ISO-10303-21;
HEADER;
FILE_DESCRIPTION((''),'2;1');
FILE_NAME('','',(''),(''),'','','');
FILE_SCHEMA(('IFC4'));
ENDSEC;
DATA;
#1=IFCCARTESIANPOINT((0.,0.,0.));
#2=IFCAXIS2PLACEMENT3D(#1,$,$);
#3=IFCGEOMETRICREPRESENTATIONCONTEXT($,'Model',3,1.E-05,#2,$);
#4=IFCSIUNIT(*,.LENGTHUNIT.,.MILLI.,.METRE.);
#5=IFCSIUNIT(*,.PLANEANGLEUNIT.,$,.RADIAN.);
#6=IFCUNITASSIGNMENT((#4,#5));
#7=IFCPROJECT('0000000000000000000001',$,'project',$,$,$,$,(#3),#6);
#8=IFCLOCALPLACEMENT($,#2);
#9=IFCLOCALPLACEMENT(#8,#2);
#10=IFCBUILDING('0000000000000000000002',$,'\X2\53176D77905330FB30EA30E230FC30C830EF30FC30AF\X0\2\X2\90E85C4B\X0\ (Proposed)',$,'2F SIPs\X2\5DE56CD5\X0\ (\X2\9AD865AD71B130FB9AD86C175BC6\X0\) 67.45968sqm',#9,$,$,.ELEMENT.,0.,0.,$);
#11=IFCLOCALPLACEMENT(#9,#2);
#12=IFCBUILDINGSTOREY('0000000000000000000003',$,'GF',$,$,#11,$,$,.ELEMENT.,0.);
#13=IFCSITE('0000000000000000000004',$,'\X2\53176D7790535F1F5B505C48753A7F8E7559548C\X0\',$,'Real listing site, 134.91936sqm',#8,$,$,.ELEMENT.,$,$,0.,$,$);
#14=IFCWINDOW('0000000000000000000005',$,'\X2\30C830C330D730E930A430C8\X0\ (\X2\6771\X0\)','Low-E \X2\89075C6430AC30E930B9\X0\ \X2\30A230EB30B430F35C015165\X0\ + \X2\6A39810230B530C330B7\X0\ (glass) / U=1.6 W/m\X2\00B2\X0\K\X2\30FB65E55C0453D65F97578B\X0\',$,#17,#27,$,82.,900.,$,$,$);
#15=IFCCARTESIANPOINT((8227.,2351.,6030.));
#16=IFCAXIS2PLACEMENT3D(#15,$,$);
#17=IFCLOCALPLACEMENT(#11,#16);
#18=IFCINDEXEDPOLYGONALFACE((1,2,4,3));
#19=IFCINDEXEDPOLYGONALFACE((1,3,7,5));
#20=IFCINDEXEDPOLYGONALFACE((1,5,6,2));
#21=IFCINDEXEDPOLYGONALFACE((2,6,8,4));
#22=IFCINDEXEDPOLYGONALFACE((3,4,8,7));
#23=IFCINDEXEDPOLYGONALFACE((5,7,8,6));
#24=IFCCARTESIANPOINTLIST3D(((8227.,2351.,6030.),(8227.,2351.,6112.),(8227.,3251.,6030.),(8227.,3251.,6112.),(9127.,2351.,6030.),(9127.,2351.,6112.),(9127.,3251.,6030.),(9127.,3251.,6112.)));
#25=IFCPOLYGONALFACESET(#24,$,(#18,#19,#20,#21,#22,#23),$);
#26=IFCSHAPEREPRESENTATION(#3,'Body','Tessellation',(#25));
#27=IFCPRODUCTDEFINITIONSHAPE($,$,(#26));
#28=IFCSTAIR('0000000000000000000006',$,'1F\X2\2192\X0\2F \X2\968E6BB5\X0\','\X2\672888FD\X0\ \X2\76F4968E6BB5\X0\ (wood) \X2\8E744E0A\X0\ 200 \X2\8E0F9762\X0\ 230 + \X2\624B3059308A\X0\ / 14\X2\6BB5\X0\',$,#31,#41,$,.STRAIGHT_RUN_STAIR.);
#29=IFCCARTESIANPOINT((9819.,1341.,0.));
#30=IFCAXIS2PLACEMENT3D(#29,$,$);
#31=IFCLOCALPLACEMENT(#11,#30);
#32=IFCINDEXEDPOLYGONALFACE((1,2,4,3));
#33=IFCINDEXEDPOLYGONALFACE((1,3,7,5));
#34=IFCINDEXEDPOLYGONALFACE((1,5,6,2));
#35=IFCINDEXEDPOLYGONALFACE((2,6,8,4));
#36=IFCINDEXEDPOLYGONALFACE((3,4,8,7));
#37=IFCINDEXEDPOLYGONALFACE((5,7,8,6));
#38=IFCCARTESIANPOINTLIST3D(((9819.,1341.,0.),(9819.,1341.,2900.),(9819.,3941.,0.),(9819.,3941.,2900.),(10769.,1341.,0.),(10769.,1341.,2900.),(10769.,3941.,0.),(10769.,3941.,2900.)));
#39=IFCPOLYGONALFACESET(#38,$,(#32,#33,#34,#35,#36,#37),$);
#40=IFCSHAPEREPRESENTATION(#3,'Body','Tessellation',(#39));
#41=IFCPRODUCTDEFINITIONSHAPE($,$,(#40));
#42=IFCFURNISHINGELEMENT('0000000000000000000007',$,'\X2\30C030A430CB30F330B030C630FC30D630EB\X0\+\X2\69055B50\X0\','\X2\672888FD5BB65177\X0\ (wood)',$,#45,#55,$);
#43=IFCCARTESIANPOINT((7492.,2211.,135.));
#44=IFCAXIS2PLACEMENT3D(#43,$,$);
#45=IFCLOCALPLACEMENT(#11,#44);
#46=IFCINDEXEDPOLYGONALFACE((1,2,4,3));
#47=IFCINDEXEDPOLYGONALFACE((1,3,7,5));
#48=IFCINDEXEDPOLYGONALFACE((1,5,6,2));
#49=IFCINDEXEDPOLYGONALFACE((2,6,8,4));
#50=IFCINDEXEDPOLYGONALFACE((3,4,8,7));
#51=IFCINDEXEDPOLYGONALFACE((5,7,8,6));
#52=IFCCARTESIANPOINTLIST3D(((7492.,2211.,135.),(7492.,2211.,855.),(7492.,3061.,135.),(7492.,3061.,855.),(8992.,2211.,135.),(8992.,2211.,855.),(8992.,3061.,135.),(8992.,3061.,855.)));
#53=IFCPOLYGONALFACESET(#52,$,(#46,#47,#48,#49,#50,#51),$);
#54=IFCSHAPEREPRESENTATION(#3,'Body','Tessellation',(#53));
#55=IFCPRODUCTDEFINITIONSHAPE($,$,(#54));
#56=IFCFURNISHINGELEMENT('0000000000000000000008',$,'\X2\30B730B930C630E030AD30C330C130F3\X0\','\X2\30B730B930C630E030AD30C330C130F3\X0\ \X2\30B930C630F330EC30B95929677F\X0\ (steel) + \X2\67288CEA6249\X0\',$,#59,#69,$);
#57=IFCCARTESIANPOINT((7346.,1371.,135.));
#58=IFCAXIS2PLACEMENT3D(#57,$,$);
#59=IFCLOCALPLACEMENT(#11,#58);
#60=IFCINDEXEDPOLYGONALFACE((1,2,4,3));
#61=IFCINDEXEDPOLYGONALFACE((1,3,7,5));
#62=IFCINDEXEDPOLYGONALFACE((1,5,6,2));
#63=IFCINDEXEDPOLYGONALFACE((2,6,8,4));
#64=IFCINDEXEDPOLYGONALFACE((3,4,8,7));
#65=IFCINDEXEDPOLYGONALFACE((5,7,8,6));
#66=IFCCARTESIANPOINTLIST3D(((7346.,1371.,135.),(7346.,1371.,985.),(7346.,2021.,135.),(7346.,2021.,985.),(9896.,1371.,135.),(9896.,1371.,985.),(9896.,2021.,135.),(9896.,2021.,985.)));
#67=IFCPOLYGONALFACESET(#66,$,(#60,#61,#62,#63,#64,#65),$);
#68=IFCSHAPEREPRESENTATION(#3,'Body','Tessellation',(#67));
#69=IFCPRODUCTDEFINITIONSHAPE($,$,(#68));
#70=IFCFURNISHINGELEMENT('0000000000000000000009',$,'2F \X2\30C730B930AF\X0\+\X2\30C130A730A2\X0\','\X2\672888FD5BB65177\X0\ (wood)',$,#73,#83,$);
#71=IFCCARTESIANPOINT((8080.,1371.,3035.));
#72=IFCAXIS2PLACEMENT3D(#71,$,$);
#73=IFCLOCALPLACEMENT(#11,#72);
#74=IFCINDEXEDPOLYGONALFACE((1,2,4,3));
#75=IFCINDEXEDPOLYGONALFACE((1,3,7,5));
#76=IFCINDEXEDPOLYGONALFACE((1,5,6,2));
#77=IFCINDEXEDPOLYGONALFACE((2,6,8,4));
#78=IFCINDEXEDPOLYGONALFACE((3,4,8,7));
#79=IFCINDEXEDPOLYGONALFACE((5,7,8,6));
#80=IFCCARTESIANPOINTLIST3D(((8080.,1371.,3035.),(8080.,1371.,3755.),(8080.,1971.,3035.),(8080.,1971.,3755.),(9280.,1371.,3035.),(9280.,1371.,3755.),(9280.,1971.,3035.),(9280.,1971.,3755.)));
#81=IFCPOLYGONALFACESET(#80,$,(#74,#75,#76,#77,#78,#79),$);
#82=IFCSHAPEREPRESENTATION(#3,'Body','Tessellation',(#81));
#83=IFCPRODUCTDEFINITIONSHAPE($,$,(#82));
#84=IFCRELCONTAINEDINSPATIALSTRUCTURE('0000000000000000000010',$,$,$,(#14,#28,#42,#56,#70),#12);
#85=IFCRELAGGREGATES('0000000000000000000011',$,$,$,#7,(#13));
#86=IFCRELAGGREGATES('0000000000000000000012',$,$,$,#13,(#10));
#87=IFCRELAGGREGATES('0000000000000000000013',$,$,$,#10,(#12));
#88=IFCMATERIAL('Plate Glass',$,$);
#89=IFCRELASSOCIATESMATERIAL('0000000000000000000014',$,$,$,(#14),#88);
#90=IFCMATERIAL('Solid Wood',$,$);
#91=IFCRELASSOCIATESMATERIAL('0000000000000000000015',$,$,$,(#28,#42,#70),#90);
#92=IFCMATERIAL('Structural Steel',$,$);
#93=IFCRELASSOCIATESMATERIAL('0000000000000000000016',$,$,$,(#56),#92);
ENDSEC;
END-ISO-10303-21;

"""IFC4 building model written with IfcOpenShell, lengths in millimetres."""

from ifc_helpers import new_model, si_unit, frame, frame_2d, origin, place, context, project, spatial, rectangle, extrude, material, element, save


model = new_model("IFC4")

# Units and contexts
model_context = context("Model", 3, precision=1e-05, world=origin())
ifc_project = project(units=[si_unit("LENGTHUNIT", "METRE", prefix="MILLI"), si_unit("PLANEANGLEUNIT", "RADIAN")], contexts=[model_context])

# Site, building, storey
site_placement = place(None, origin())
site = spatial("IfcSite", under=ifc_project, at=site_placement, Name="北海道弟子屈町美留和", ObjectType="Real listing site, 134.91936sqm", CompositionType="ELEMENT", RefElevation=0.0)
building_placement = place(site_placement, origin())
building = spatial("IfcBuilding", under=site, at=building_placement, Name="北海道・リモートワーク2部屋 (Proposed)", ObjectType="2F SIPs工法 (高断熱・高気密) 67.45968sqm", CompositionType="ELEMENT", ElevationOfRefHeight=0.0, ElevationOfTerrain=0.0)
storey_placement = place(building_placement, origin())
storey = spatial("IfcBuildingStorey", under=building, at=storey_placement, Name="GF", CompositionType="ELEMENT", Elevation=0.0)

# Shared definitions
ifc_material_1 = material(Name="Solid Wood")

# Shared definitions
ifc_material_2 = material(Name="Plate Glass")

# Window
window_1_placement = place(storey_placement, frame((8227.0, 2351.0, 6030.0)))
element("IfcWindow", 1, at=window_1_placement, inside=storey, material=ifc_material_2, Name="トップライト (東)", Description="Low-E 複層ガラス アルゴン封入 + 樹脂サッシ (glass) / U=1.6 W/m²K・日射取得型", OverallHeight=82.0, OverallWidth=900.0, context=model_context, shape_type="SweptSolid", body=[
    extrude(rectangle(XDim=900.0, YDim=900.0, at=frame_2d((450.0, 450.0))), frame((8227.0, 2351.0, 6030.0)), (0.0, 0.0, 1.0), 82.0),
])

# Stair
stair_placement = place(storey_placement, frame((9819.0, 1341.0, 0.0)))
element("IfcStair", 2, at=stair_placement, inside=storey, material=ifc_material_1, Name="1F→2F 階段", Description="木製 直階段 (wood) 蹴上 200 踏面 230 + 手すり / 14段", PredefinedType="STRAIGHT_RUN_STAIR", context=model_context, shape_type="SweptSolid", body=[
    extrude(rectangle(XDim=950.0, YDim=2600.0, at=frame_2d((475.0, 1300.0))), frame((9819.0, 1341.0, 0.0)), (0.0, 0.0, 1.0), 2900.0),
])

# Furnishing elements
furnishing_1_placement = place(storey_placement, frame((7492.0, 2211.0, 135.0)))
element("IfcFurnishingElement", 3, at=furnishing_1_placement, inside=storey, material=ifc_material_1, Name="ダイニングテーブル+椅子", Description="木製家具 (wood)", context=model_context, shape_type="SweptSolid", body=[
    extrude(rectangle(XDim=1500.0, YDim=850.0, at=frame_2d((750.0, 425.0))), frame((7492.0, 2211.0, 135.0)), (0.0, 0.0, 1.0), 720.0),
])
ifc_material_3 = material(Name="Structural Steel")
furnishing_2_placement = place(storey_placement, frame((7346.0, 1371.0, 135.0)))
element("IfcFurnishingElement", 4, at=furnishing_2_placement, inside=storey, material=ifc_material_3, Name="システムキッチン", Description="システムキッチン ステンレス天板 (steel) + 木質扉", context=model_context, shape_type="SweptSolid", body=[
    extrude(rectangle(XDim=2550.0, YDim=650.0, at=frame_2d((1275.0, 325.0))), frame((7346.0, 1371.0, 135.0)), (0.0, 0.0, 1.0), 850.0),
])
furnishing_3_placement = place(storey_placement, frame((8080.0, 1371.0, 3035.0)))
element("IfcFurnishingElement", 5, at=furnishing_3_placement, inside=storey, material=ifc_material_1, Name="2F デスク+チェア", Description="木製家具 (wood)", context=model_context, shape_type="SweptSolid", body=[
    extrude(rectangle(XDim=1200.0, YDim=600.0, at=frame_2d((600.0, 300.0))), frame((8080.0, 1371.0, 3035.0)), (0.0, 0.0, 1.0), 720.0),
])

save(model, "model.ifc")
